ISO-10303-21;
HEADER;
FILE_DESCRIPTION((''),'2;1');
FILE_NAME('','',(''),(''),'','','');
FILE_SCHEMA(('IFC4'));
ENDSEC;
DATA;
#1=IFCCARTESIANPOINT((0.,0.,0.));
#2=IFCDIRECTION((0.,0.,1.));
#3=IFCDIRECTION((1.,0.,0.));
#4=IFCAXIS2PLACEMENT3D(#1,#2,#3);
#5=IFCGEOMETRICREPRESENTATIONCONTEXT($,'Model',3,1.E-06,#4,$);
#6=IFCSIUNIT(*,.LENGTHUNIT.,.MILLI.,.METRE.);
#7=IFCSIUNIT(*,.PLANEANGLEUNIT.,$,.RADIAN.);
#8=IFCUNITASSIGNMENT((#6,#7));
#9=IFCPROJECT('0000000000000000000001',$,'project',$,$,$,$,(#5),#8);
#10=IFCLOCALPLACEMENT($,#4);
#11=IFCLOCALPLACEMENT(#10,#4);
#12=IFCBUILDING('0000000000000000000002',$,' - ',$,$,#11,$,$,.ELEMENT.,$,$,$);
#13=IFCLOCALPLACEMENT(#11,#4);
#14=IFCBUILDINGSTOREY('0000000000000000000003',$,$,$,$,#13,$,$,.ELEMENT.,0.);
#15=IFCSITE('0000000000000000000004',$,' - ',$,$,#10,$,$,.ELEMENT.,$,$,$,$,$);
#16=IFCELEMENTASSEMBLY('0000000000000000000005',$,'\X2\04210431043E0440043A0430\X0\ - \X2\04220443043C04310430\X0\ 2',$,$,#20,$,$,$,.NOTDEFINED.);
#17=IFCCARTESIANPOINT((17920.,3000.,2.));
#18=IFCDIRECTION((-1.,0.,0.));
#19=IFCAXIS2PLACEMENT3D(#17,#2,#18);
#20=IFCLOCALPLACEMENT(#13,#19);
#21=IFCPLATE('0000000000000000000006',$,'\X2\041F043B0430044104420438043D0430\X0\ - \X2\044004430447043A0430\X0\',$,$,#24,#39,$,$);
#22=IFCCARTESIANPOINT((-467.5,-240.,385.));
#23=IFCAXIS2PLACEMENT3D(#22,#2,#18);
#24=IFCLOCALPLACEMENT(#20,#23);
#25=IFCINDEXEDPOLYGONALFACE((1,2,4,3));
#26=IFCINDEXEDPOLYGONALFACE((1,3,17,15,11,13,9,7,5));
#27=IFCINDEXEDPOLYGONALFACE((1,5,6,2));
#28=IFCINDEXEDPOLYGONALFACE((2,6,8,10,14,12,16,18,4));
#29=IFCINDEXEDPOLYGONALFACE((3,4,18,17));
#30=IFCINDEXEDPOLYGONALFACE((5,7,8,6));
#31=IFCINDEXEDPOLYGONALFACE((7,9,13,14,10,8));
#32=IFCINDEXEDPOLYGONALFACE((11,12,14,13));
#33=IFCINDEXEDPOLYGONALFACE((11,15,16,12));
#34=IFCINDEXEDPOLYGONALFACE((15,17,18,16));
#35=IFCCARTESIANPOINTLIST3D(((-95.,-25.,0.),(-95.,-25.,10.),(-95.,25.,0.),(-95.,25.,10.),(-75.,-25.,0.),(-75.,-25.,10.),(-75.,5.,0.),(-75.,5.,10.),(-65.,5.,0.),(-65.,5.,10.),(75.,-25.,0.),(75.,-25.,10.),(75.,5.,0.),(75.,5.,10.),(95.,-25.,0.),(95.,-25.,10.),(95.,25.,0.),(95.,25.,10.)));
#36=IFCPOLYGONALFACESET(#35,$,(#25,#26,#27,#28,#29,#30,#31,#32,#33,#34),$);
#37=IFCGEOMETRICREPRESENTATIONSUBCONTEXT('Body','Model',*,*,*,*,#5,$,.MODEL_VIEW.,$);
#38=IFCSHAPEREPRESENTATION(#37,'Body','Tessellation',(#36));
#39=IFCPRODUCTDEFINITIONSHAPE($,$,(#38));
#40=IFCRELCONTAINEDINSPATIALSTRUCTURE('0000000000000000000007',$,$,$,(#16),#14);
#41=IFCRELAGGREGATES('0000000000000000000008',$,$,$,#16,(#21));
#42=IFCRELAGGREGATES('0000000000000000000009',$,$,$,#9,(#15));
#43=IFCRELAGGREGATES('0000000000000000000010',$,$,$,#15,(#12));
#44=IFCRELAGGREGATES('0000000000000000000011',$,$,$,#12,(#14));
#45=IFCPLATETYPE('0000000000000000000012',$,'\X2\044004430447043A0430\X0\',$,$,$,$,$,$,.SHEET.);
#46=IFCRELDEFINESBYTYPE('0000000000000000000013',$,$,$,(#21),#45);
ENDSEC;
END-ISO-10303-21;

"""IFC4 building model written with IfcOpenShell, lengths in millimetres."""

from ifc_helpers import new_model, si_unit, frame, origin_with_axes, place, context, subcontext, project, spatial, line, indexed_curve, outline, extrude, source, transform, mapped, type_object, element, aggregate, save


model = new_model("IFC4")

# Units and contexts
model_context = context("Model", 3, precision=1e-06, world=origin_with_axes())
body_context = subcontext(model_context, "Body", "Model", "MODEL_VIEW")
ifc_project = project(units=[si_unit("LENGTHUNIT", "METRE", prefix="MILLI"), si_unit("PLANEANGLEUNIT", "RADIAN")], contexts=[model_context])

# Site, building, storey
site_placement = place(None, origin_with_axes())
site = spatial("IfcSite", under=ifc_project, at=site_placement, Name=" - ", CompositionType="ELEMENT")
building_placement = place(site_placement, origin_with_axes())
building = spatial("IfcBuilding", under=site, at=building_placement, Name=" - ", CompositionType="ELEMENT")
storey_placement = place(building_placement, origin_with_axes())
storey = spatial("IfcBuildingStorey", under=building, at=storey_placement, CompositionType="ELEMENT", Elevation=0.0)

# Element assembly, plate
assembly_1_placement = place(storey_placement, frame((17920.0, 3000.0, 2.0), z_axis=(0.0, 0.0, 1.0), x_axis=(-1.0, 0.0, 0.0)))
assembly_1 = element("IfcElementAssembly", 1, at=assembly_1_placement, inside=storey, Name="Сборка - Тумба 2", PredefinedType="NOTDEFINED")
plate_type = type_object("IfcPlateType", Name="ручка", PredefinedType="SHEET")
shared_shape = source(origin_with_axes(), body_context, "Body", "SweptSolid", [
    extrude(outline(indexed_curve([(-95.0, -25.0), (-75.0, -25.0), (-75.0, 5.0), (-65.0, 5.0), (75.0, 5.0), (75.0, -25.0), (95.0, -25.0), (95.0, 25.0), (-95.0, 25.0)], segments=[line(1, 2), line(2, 3), line(3, 4), line(4, 5), line(5, 6), line(6, 7), line(7, 8), line(8, 9), line(9, 1)])), origin_with_axes(), (0.0, 0.0, 1.0), 10.0),
])
plate_1_placement = place(assembly_1_placement, frame((-467.5, -240.0, 385.0), z_axis=(0.0, 0.0, 1.0), x_axis=(-1.0, 0.0, 0.0)))
plate_1 = element("IfcPlate", 2, at=plate_1_placement, type_object=plate_type, Name="Пластина - ручка", context=body_context, shape_type="MappedRepresentation", body=[
    mapped(shared_shape, transform((0.0, 0.0, 0.0), x_axis=(1.0, 0.0, 0.0), y_axis=(0.0, 1.0, 0.0), z_axis=(0.0, 0.0, 1.0), scale=1.0)),
])
aggregate(assembly_1, [plate_1])

save(model, "model.ifc")
